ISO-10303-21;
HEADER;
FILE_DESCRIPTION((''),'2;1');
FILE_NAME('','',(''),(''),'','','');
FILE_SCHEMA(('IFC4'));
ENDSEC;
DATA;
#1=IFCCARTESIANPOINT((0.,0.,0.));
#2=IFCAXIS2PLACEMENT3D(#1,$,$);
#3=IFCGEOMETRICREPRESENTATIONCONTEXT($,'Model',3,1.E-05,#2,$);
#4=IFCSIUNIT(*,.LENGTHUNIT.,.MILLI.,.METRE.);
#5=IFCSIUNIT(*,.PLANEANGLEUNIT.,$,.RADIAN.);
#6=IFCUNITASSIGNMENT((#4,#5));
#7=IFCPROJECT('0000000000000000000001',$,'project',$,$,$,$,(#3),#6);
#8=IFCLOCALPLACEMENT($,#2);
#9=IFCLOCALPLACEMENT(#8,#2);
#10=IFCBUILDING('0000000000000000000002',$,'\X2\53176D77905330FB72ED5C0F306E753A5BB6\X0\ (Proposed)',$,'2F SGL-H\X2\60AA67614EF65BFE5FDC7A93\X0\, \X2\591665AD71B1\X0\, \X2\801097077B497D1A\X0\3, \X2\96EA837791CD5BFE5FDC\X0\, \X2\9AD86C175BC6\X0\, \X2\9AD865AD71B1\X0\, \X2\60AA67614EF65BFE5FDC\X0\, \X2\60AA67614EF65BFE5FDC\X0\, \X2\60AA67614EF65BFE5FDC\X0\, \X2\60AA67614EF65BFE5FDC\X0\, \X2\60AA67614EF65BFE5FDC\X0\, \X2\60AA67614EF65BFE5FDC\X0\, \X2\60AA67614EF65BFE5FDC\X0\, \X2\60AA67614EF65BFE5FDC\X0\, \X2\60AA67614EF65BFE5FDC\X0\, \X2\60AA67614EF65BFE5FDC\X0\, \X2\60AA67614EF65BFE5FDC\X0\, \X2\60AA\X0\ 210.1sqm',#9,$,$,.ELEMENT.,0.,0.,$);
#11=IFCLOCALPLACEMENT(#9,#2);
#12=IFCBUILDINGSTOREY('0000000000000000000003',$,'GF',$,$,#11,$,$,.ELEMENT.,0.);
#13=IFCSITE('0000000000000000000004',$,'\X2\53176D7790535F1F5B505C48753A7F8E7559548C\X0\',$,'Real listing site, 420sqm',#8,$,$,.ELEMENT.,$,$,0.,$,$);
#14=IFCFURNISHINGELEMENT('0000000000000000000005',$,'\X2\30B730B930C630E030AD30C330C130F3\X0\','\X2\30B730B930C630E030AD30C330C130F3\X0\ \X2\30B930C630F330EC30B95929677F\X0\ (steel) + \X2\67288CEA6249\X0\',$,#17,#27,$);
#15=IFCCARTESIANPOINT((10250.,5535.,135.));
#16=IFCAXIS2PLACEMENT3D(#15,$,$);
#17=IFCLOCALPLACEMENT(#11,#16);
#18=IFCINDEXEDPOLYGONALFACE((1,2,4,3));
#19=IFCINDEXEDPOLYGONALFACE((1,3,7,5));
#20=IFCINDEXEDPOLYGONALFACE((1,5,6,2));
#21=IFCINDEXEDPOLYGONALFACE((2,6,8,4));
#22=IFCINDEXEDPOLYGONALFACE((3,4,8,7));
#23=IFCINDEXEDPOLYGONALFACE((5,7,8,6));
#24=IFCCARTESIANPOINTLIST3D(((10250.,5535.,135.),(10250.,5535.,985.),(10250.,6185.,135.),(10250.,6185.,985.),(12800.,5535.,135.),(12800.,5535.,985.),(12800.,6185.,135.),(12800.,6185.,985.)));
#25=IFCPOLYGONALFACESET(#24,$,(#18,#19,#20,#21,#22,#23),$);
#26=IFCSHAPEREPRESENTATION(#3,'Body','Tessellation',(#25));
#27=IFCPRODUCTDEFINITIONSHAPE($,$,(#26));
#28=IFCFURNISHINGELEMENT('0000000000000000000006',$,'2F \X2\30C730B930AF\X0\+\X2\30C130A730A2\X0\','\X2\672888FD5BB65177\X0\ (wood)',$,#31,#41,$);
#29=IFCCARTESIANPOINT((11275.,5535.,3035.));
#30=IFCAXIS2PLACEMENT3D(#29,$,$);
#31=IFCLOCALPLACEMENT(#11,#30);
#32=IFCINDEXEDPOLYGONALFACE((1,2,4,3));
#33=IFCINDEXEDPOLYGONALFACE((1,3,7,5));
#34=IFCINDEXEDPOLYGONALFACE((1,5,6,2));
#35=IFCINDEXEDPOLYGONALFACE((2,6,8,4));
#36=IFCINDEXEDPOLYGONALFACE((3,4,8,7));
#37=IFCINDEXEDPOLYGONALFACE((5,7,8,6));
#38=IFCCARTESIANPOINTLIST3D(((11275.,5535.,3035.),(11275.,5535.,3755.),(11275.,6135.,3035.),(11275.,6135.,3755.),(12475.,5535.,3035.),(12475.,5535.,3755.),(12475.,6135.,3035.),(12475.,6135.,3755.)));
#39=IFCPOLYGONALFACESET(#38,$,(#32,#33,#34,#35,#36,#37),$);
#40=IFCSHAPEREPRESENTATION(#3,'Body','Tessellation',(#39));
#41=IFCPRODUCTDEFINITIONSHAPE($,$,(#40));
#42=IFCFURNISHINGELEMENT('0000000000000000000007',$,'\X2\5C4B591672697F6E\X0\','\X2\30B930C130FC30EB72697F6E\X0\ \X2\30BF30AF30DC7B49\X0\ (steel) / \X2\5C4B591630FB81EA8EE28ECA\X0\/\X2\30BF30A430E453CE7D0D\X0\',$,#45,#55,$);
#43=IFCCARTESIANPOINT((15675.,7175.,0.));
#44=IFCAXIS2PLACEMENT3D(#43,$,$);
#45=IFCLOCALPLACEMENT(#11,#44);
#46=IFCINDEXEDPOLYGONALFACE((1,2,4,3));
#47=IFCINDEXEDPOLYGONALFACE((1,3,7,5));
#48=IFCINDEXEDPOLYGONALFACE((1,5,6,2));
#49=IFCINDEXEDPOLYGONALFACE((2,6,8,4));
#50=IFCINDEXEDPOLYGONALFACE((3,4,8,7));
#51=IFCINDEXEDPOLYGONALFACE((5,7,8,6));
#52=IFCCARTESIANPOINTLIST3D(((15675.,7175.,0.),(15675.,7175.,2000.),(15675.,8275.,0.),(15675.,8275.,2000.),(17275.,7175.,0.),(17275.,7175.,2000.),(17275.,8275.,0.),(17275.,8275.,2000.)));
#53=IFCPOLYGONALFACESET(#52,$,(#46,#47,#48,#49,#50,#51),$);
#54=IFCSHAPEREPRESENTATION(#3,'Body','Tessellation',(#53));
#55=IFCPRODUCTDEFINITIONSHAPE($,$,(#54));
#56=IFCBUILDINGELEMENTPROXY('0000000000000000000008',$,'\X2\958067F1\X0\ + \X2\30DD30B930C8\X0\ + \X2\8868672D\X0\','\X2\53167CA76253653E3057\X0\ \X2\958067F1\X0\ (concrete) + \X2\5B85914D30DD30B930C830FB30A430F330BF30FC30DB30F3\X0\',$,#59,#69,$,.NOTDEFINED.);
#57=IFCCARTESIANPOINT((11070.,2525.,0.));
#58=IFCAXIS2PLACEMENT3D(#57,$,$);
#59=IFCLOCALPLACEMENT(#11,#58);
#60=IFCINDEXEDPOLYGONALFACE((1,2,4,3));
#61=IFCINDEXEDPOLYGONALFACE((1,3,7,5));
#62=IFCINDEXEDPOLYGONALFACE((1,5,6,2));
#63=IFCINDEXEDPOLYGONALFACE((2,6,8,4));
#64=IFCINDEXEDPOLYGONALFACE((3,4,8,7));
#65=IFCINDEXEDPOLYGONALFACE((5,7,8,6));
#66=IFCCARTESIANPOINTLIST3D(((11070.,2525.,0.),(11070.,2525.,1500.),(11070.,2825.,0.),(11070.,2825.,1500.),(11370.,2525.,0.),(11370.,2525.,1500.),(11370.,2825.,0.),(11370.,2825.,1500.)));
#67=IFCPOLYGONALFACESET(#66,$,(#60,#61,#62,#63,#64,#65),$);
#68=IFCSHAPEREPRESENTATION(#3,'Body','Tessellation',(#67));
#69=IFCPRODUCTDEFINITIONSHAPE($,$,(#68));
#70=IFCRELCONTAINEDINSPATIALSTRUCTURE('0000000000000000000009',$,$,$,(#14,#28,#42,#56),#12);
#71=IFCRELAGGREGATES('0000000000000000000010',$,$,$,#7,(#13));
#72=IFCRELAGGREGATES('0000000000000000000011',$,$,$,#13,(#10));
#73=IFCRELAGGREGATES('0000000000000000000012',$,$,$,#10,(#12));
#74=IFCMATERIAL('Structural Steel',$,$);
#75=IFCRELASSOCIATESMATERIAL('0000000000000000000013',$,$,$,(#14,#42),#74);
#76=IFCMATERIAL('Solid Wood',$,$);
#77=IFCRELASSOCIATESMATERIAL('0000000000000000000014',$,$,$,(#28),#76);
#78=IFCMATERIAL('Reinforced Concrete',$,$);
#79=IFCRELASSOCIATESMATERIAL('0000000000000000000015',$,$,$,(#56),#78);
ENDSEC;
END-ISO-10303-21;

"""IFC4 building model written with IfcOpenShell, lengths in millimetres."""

from ifc_helpers import new_model, si_unit, frame, frame_2d, origin, place, context, project, spatial, rectangle, extrude, material, element, save


model = new_model("IFC4")

# Units and contexts
model_context = context("Model", 3, precision=1e-05, world=origin())
ifc_project = project(units=[si_unit("LENGTHUNIT", "METRE", prefix="MILLI"), si_unit("PLANEANGLEUNIT", "RADIAN")], contexts=[model_context])

# Site, building, storey
site_placement = place(None, origin())
site = spatial("IfcSite", under=ifc_project, at=site_placement, Name="北海道弟子屈町美留和", ObjectType="Real listing site, 420sqm", CompositionType="ELEMENT", RefElevation=0.0)
building_placement = place(site_placement, origin())
building = spatial("IfcBuilding", under=site, at=building_placement, Name="北海道・狭小の町家 (Proposed)", ObjectType="2F SGL-H悪条件対応窓, 外断熱, 耐震等級3, 雪荷重対応, 高気密, 高断熱, 悪条件対応, 悪条件対応, 悪条件対応, 悪条件対応, 悪条件対応, 悪条件対応, 悪条件対応, 悪条件対応, 悪条件対応, 悪条件対応, 悪条件対応, 悪 210.1sqm", CompositionType="ELEMENT", ElevationOfRefHeight=0.0, ElevationOfTerrain=0.0)
storey_placement = place(building_placement, origin())
storey = spatial("IfcBuildingStorey", under=building, at=storey_placement, Name="GF", CompositionType="ELEMENT", Elevation=0.0)

# Shared definitions
ifc_material_1 = material(Name="Solid Wood")

# Shared definitions
ifc_material_2 = material(Name="Reinforced Concrete")

# Shared definitions
ifc_material_3 = material(Name="Structural Steel")

# Furnishing elements
furnishing_1_placement = place(storey_placement, frame((10250.0, 5535.0, 135.0)))
element("IfcFurnishingElement", 1, at=furnishing_1_placement, inside=storey, material=ifc_material_3, Name="システムキッチン", Description="システムキッチン ステンレス天板 (steel) + 木質扉", context=model_context, shape_type="SweptSolid", body=[
    extrude(rectangle(XDim=2550.0, YDim=650.0, at=frame_2d((1275.0, 325.0))), frame((10250.0, 5535.0, 135.0)), (0.0, 0.0, 1.0), 850.0),
])
furnishing_2_placement = place(storey_placement, frame((11275.0, 5535.0, 3035.0)))
element("IfcFurnishingElement", 2, at=furnishing_2_placement, inside=storey, material=ifc_material_1, Name="2F デスク+チェア", Description="木製家具 (wood)", context=model_context, shape_type="SweptSolid", body=[
    extrude(rectangle(XDim=1200.0, YDim=600.0, at=frame_2d((600.0, 300.0))), frame((11275.0, 5535.0, 3035.0)), (0.0, 0.0, 1.0), 720.0),
])
furnishing_3_placement = place(storey_placement, frame((15675.0, 7175.0, 0.0)))
element("IfcFurnishingElement", 3, at=furnishing_3_placement, inside=storey, material=ifc_material_3, Name="屋外物置", Description="スチール物置 タクボ等 (steel) / 屋外・自転車/タイヤ収納", context=model_context, shape_type="SweptSolid", body=[
    extrude(rectangle(XDim=1600.0, YDim=1100.0, at=frame_2d((800.0, 550.0))), frame((15675.0, 7175.0, 0.0)), (0.0, 0.0, 1.0), 2000.0),
])

# Building element proxy
proxy_placement = place(storey_placement, frame((11070.0, 2525.0, 0.0)))
element("IfcBuildingElementProxy", 4, at=proxy_placement, inside=storey, material=ifc_material_2, Name="門柱 + ポスト + 表札", Description="化粧打放し 門柱 (concrete) + 宅配ポスト・インターホン", PredefinedType="NOTDEFINED", context=model_context, shape_type="SweptSolid", body=[
    extrude(rectangle(XDim=300.0, YDim=300.0, at=frame_2d((150.0, 150.0))), frame((11070.0, 2525.0, 0.0)), (0.0, 0.0, 1.0), 1500.0),
])

save(model, "model.ifc")
